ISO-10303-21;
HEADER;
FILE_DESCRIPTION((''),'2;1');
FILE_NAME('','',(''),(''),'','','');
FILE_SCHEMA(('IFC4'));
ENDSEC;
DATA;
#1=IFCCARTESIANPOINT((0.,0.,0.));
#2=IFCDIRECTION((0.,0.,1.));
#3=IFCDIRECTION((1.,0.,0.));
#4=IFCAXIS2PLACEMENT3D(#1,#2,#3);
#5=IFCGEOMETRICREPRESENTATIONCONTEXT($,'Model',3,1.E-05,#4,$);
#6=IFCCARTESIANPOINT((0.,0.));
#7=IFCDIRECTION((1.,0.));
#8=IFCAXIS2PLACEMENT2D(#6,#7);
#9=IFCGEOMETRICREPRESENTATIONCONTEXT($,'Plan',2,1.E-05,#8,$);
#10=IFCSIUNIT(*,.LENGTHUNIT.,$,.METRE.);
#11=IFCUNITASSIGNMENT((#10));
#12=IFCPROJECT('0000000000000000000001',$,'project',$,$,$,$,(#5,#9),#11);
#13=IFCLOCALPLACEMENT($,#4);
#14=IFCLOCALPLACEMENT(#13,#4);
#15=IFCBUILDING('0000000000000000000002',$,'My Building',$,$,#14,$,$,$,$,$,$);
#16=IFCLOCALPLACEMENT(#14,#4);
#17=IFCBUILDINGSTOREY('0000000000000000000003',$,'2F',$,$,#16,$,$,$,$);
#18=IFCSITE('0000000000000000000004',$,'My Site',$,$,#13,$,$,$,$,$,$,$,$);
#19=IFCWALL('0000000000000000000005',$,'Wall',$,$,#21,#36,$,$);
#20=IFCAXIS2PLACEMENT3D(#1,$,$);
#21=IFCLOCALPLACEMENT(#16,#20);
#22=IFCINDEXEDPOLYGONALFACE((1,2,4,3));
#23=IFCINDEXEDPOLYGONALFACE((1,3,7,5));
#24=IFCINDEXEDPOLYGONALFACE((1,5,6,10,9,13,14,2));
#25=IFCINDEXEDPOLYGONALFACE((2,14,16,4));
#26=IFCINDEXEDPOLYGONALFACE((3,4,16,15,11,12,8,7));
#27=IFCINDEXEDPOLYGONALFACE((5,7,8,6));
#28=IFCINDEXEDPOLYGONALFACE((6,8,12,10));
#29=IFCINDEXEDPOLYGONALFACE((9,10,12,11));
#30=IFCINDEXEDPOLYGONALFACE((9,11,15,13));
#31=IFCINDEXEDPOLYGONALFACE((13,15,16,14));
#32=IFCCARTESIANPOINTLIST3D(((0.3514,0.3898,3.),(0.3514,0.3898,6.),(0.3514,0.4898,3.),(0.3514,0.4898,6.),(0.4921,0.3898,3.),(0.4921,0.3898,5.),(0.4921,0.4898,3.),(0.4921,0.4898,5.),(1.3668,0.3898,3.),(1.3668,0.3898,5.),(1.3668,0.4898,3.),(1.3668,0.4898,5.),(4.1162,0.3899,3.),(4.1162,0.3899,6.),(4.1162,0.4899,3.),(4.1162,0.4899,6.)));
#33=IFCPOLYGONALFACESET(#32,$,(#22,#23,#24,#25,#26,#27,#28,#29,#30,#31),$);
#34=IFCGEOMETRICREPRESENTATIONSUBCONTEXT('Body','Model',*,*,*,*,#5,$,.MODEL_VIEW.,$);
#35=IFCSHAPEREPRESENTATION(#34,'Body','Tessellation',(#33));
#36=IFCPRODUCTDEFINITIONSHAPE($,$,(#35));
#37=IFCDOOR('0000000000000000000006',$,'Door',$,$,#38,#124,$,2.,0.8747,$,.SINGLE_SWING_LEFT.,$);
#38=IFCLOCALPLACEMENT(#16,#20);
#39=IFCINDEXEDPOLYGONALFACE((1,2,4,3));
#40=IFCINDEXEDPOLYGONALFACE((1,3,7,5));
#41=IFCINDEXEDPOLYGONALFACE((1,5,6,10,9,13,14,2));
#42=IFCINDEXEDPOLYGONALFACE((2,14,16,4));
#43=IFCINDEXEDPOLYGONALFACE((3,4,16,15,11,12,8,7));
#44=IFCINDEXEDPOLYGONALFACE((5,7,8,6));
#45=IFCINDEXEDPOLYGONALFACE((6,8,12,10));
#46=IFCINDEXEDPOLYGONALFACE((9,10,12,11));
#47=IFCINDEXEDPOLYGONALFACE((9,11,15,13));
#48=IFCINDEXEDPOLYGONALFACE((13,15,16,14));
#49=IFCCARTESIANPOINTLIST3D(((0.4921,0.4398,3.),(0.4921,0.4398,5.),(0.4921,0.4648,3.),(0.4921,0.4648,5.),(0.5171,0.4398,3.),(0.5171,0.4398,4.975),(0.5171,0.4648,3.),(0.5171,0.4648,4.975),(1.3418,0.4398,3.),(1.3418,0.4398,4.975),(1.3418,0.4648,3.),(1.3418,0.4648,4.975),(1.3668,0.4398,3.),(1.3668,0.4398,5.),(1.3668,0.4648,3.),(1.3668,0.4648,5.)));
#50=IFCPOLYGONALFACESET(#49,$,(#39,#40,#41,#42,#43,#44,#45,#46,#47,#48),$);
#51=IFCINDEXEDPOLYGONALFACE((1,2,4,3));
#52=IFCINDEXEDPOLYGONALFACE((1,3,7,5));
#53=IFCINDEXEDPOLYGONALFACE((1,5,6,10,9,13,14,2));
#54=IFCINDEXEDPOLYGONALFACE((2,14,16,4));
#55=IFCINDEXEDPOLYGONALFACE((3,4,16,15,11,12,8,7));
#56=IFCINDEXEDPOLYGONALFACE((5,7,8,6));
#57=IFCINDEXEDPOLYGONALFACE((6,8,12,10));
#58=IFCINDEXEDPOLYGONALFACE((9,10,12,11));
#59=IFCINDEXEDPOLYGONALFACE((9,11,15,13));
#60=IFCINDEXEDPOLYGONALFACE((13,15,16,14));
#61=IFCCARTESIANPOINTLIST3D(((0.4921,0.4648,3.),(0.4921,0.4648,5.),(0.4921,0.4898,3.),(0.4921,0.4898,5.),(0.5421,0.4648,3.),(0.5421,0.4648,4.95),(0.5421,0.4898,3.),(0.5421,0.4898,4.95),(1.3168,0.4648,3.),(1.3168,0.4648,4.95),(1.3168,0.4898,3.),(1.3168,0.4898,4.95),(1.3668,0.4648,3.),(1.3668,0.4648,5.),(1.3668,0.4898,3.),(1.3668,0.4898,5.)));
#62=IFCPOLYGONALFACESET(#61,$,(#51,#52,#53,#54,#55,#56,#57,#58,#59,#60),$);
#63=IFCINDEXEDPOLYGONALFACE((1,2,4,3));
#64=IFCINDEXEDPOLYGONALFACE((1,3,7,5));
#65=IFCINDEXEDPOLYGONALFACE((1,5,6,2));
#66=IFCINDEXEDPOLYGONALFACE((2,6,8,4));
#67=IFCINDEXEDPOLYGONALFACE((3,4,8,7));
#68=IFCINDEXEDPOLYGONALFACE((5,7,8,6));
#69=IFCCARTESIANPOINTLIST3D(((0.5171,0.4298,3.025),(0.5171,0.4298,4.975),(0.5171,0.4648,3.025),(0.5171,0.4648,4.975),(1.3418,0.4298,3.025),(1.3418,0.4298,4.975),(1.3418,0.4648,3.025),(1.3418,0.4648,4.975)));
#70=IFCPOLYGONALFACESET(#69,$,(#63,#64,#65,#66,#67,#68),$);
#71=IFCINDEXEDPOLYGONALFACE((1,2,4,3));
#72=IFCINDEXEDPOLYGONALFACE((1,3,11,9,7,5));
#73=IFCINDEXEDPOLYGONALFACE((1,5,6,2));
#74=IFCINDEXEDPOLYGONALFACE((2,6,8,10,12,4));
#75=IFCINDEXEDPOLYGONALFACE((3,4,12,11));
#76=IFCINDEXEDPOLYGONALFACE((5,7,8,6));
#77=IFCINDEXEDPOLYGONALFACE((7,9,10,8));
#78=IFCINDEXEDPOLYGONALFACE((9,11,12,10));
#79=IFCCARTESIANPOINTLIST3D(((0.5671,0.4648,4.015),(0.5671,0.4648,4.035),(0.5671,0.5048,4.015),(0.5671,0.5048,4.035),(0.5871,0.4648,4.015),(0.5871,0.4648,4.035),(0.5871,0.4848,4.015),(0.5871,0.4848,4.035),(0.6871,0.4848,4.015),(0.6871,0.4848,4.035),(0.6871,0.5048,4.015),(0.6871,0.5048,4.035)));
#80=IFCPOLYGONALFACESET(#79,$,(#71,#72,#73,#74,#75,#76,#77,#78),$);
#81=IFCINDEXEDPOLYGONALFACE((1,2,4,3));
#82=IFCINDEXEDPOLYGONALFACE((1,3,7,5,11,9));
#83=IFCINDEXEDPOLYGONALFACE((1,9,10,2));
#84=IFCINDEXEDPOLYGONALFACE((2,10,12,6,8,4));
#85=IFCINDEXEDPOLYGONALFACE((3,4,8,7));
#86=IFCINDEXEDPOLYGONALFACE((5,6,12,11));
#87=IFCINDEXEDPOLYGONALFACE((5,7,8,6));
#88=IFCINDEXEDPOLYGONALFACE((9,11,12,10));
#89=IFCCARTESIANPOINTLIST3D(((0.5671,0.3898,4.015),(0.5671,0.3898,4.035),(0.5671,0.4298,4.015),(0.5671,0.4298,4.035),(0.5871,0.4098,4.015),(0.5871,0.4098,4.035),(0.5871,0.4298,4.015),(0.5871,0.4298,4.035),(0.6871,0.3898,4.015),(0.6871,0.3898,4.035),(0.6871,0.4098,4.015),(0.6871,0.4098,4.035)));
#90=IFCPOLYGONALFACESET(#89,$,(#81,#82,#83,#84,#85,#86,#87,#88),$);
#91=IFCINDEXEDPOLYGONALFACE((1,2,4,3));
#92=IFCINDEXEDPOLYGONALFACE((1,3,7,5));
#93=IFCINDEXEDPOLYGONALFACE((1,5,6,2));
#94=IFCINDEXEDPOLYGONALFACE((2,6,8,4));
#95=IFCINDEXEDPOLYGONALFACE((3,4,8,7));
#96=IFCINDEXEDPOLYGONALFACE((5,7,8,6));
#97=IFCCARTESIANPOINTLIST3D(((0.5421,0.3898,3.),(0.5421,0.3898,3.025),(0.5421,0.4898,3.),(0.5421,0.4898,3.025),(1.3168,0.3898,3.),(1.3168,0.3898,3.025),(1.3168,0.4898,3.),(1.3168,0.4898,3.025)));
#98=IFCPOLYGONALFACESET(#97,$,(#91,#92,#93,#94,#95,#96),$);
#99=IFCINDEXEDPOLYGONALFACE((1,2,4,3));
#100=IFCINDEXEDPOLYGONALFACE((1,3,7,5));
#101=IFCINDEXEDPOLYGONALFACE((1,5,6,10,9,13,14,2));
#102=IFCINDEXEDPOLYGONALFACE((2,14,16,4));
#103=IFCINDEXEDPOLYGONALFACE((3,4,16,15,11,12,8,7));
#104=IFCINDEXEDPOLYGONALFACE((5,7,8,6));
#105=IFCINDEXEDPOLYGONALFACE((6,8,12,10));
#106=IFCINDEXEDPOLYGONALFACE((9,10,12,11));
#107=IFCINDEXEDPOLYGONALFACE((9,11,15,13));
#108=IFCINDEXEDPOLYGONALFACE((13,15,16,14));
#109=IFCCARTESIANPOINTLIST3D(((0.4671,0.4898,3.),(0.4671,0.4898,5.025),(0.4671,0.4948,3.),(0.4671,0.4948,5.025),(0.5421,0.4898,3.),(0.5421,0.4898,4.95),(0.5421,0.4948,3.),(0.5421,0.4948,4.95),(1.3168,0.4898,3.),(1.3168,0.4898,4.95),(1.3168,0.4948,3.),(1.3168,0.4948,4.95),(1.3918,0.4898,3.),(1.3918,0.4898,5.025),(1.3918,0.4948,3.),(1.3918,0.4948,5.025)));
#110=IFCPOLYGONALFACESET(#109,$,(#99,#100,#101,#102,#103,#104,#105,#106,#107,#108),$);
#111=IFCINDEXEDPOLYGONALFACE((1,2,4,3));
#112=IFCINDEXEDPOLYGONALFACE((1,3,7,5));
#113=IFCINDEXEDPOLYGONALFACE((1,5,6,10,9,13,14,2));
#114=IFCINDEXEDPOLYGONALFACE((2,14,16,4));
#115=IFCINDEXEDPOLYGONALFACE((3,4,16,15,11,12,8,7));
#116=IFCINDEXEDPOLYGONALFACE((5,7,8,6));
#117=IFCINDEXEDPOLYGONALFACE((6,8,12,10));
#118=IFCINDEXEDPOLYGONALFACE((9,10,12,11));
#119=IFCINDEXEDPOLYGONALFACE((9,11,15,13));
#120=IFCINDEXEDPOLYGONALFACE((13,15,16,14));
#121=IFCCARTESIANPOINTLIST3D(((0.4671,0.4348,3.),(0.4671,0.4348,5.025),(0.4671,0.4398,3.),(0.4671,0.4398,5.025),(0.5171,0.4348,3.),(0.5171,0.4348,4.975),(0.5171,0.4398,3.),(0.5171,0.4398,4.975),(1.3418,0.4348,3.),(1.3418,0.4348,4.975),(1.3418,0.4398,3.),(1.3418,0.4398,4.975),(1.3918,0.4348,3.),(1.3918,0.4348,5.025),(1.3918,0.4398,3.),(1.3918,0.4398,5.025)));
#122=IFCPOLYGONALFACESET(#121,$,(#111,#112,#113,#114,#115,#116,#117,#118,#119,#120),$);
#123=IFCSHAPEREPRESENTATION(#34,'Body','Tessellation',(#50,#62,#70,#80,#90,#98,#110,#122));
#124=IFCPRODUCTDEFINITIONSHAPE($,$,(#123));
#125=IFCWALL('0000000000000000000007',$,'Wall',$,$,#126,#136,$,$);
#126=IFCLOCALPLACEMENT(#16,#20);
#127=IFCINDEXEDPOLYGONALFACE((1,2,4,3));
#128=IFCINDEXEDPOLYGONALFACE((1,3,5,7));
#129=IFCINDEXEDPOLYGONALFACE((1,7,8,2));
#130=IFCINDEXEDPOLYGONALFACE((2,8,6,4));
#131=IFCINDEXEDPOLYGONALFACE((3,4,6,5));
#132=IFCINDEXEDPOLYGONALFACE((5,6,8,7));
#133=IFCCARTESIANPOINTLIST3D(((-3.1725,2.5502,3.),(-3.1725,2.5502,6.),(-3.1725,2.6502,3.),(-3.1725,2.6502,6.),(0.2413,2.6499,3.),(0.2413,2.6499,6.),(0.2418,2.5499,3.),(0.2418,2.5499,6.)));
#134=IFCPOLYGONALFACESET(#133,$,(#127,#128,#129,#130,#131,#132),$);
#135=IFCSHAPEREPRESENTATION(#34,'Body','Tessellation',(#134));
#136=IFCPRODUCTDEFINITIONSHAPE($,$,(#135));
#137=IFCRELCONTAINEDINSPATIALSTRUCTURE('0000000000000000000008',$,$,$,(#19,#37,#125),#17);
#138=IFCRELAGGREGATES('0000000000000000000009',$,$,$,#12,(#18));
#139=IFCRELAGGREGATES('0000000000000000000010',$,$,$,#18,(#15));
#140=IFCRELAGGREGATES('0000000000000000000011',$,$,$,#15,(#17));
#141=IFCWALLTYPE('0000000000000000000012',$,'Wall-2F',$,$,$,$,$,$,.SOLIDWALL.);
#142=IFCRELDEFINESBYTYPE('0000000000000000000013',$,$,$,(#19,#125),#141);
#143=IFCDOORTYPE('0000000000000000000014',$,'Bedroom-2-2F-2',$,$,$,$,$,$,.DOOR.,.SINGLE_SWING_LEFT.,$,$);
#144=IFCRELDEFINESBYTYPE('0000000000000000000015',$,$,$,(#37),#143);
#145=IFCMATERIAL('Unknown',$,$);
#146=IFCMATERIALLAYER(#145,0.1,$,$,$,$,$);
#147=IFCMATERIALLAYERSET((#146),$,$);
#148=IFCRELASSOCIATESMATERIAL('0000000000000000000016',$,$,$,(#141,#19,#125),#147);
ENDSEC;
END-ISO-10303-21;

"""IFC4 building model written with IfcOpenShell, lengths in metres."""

from ifc_helpers import new_model, entity, si_unit, frame, origin_with_axes, origin_2d_with_axis, place, context, subcontext, project, spatial, line, indexed_curve, outline, extrude, shape, source, transform, mapped, material, layer, layer_set, layer_usage, type_object, type_shapes, element, fill, save


model = new_model("IFC4")

# Units and contexts
model_context = context("Model", 3, precision=1e-05, world=origin_with_axes())
plan_context = context("Plan", 2, precision=1e-05, world=origin_2d_with_axis())
body_context_1 = subcontext(model_context, "Body", "Model", "MODEL_VIEW")
body_context_2 = subcontext(plan_context, "Body", "Plan", "PLAN_VIEW")
ifc_project = project(units=[si_unit("LENGTHUNIT", "METRE")], contexts=[model_context, plan_context])

# Site, building, storey
site_placement = place(None, origin_with_axes())
site = spatial("IfcSite", under=ifc_project, at=site_placement, Name="My Site")
building_placement = place(site_placement, origin_with_axes())
building = spatial("IfcBuilding", under=site, at=building_placement, Name="My Building")
storey_placement = place(building_placement, origin_with_axes())
storey = spatial("IfcBuildingStorey", under=building, at=storey_placement, Name="2F")

# Shared definitions
ifc_material = material(Name="Unknown")

# Shared definitions
ifc_layer_1 = layer(ifc_material, 0.1)
ifc_layer_set_1 = layer_set([ifc_layer_1])
wall_type = type_object("IfcWallType", Name="Wall-2F", PredefinedType="SOLIDWALL", material=ifc_layer_set_1)

# Wall, opening, door
ifc_layer_usage_1 = layer_usage(ifc_layer_set_1, "AXIS2", "POSITIVE", 0.0)
wall_1_placement = place(storey_placement, frame((0.3514, 0.3898, 3.0), z_axis=(0.0, 0.0, 1.0), x_axis=(1.0, 0.000024, 0.0)))
wall_1 = element("IfcWall", 1, at=wall_1_placement, inside=storey, type_object=wall_type, material=ifc_layer_usage_1, Name="Wall", context=body_context_1, shape_type="SweptSolid", body=[
    extrude(outline(indexed_curve([(0.0, 0.0), (0.0, 0.1), (3.7648, 0.1), (3.7648, 0.0)], segments=[line(1, 2, 3, 4, 1)])), origin_with_axes(), (0.0, 0.0, 1.0), 3.0),
])
shared_shape_1 = source(origin_with_axes(), body_context_1, "Body", "SweptSolid", [
    extrude(outline(indexed_curve([(0.0, 0.0), (0.8747, 0.0), (0.8747, 2.0), (0.0, 2.0)], segments=[line(1, 2, 3, 4, 1)])), frame((0.0, -0.6, 0.0), z_axis=(0.0, -1.0, 0.0), x_axis=(1.0, 0.0, 0.0)), (0.0, 0.0, -1.0), 1.2),
])
opening_1_placement = place(wall_1_placement, frame((0.1407, 0.015, 0.0), z_axis=(0.0, 0.0, 1.0), x_axis=(1.0, -0.000001, 0.0)))
opening_1 = element("IfcOpeningElement", 2, at=opening_1_placement, cuts=wall_1, PredefinedType="OPENING", context=body_context_1, shape_type="MappedRepresentation", body=[
    mapped(shared_shape_1, transform((0.0, 0.0, 0.0), x_axis=(1.0, 0.0, 0.0), y_axis=(0.0, 1.0, 0.0), z_axis=(0.0, 0.0, 1.0), scale=1.0)),
])
door_type_1 = type_object("IfcDoorType", Name="Bedroom-2-2F-2", OperationType="SINGLE_SWING_LEFT", PredefinedType="DOOR")
shared_shape_2 = source(origin_with_axes(), body_context_1, "Body", "SweptSolid", [
    extrude(outline(indexed_curve([(0.0, 0.0), (0.0, 2.0), (0.8747, 2.0), (0.8747, 0.0), (0.8497, 0.0), (0.8497, 1.975), (0.025, 1.975), (0.025, 0.0)], segments=[line(1, 2, 3, 4, 5, 6, 7, 8, 1)])), frame((0.0, 0.025, 0.0), z_axis=(0.0, -1.0, 0.0), x_axis=(1.0, 0.0, 0.0)), (0.0, 0.0, -1.0), 0.025),
    extrude(outline(indexed_curve([(0.0, 0.0), (0.0, 2.0), (0.8747, 2.0), (0.8747, 0.0), (0.8247, 0.0), (0.8247, 1.95), (0.05, 1.95), (0.05, 0.0)], segments=[line(1, 2, 3, 4, 5, 6, 7, 8, 1)])), frame((0.0, 0.0, 0.0), z_axis=(0.0, -1.0, 0.0), x_axis=(1.0, 0.0, 0.0)), (0.0, 0.0, -1.0), 0.025),
    extrude(outline(indexed_curve([(0.0, 0.0), (0.8247, 0.0), (0.8247, 0.035), (0.0, 0.035)], segments=[line(1, 2, 3, 4, 1)])), frame((0.025, 0.025, 0.025), z_axis=(0.0, 0.0, 1.0), x_axis=(1.0, 0.0, 0.0)), (0.0, 0.0, 1.0), 1.95),
    extrude(outline(indexed_curve([(0.0, 0.0), (0.0, -0.04), (-0.12, -0.04), (-0.12, -0.02), (-0.02, -0.02), (-0.02, 0.0)], segments=[line(1, 2, 3, 4, 5, 6, 1)])), frame((0.7997, 0.025, 1.015), z_axis=(0.0, 0.0, 1.0), x_axis=(1.0, 0.0, 0.0)), (0.0, 0.0, 1.0), 0.02),
    extrude(outline(indexed_curve([(0.0, 0.0), (0.0, 0.04), (-0.12, 0.04), (-0.12, 0.02), (-0.02, 0.02), (-0.02, 0.0)], segments=[line(1, 2, 3, 4, 5, 6, 1)])), frame((0.7997, 0.06, 1.015), z_axis=(0.0, 0.0, 1.0), x_axis=(1.0, 0.0, 0.0)), (0.0, 0.0, 1.0), 0.02),
    extrude(outline(indexed_curve([(0.0, 0.0), (0.7747, 0.0), (0.7747, 0.1), (0.0, 0.1)], segments=[line(1, 2, 3, 4, 1)])), frame((0.05, 0.0, 0.0), z_axis=(0.0, 0.0, 1.0), x_axis=(1.0, 0.0, 0.0)), (0.0, 0.0, 1.0), 0.025),
    extrude(outline(indexed_curve([(0.0, 0.0), (0.0, 2.025), (0.9247, 2.025), (0.9247, 0.0), (0.8497, 0.0), (0.8497, 1.95), (0.075, 1.95), (0.075, 0.0)], segments=[line(1, 2, 3, 4, 5, 6, 7, 8, 1)])), frame((-0.025, -0.005, 0.0), z_axis=(0.0, -1.0, 0.0), x_axis=(1.0, 0.0, 0.0)), (0.0, 0.0, -1.0), 0.005),
    extrude(outline(indexed_curve([(0.0, 0.0), (0.0, 2.025), (0.9247, 2.025), (0.9247, 0.0), (0.8747, 0.0), (0.8747, 1.975), (0.05, 1.975), (0.05, 0.0)], segments=[line(1, 2, 3, 4, 5, 6, 7, 8, 1)])), frame((-0.025, 0.05, 0.0), z_axis=(0.0, -1.0, 0.0), x_axis=(1.0, 0.0, 0.0)), (0.0, 0.0, -1.0), 0.005),
])
shared_shape_3 = source(origin_with_axes(), body_context_2, "Body", "Curve2D", [
    entity("IfcIndexedPolyCurve", entity("IfcCartesianPointList2D", [[0.0, 0.0], [0.0, 0.05], [0.025, 0.05], [0.025, 0.025], [0.05, 0.025], [0.05, 0.0]]), [entity("IfcLineIndex", [1, 2, 3, 4, 5, 6, 1])]),
    entity("IfcIndexedPolyCurve", entity("IfcCartesianPointList2D", [[0.8747, 0.0], [0.8747, 0.05], [0.8497, 0.05], [0.8497, 0.025], [0.8247, 0.025], [0.8247, 0.0]]), [entity("IfcLineIndex", [1, 2, 3, 4, 5, 6, 1])]),
    entity("IfcTrimmedCurve", entity("IfcEllipse", entity("IfcAxis2Placement2D", entity("IfcCartesianPoint", [0.06, 0.05]), entity("IfcDirection", [1.0, 0.0])), 0.7897, 0.8247), [entity("IfcCartesianPoint", [0.8497, 0.05])], [entity("IfcCartesianPoint", [0.06, 0.8747])], True, "CARTESIAN"),
    entity("IfcIndexedPolyCurve", entity("IfcCartesianPointList2D", [[0.025, 0.05], [0.06, 0.05], [0.06, 0.8747], [0.025, 0.8747]]), [entity("IfcLineIndex", [1, 2, 3, 4, 1])]),
])
type_shapes(door_type_1, [shared_shape_2, shared_shape_3])
door_1_placement = place(opening_1_placement, frame((0.8747, 0.085, 0.0), z_axis=(0.0, 0.0, 1.0), x_axis=(-1.0, 0.0, 0.0)))
door_1 = element("IfcDoor", 3, at=door_1_placement, inside=storey, type_object=door_type_1, Name="Door", OperationType="SINGLE_SWING_LEFT", OverallHeight=2.0, OverallWidth=0.8747, shapes=[
    shape(body_context_1, "Body", "MappedRepresentation", [mapped(shared_shape_2, transform((0.0, 0.0, 0.0), x_axis=(1.0, 0.0, 0.0), y_axis=(0.0, 1.0, 0.0), z_axis=(0.0, 0.0, 1.0), scale=1.0))]),
    shape(body_context_2, "Body", "MappedRepresentation", [mapped(shared_shape_3, transform((0.0, 0.0, 0.0), x_axis=(1.0, 0.0, 0.0), y_axis=(0.0, 1.0, 0.0), z_axis=(0.0, 0.0, 1.0), scale=1.0))]),
])
fill(opening_1, door_1)

# Wall
ifc_layer_usage_2 = layer_usage(ifc_layer_set_1, "AXIS2", "POSITIVE", 0.0)
wall_2_placement = place(storey_placement, frame((-3.1725, 2.5502, 3.0), z_axis=(0.0, 0.0, 1.0), x_axis=(1.0, -0.000076, 0.0)))
element("IfcWall", 4, at=wall_2_placement, inside=storey, type_object=wall_type, material=ifc_layer_usage_2, Name="Wall", context=body_context_1, shape_type="SweptSolid", body=[
    extrude(outline(indexed_curve([(0.0, 0.0), (0.0, 0.1), (3.4138, 0.1), (3.4144, 0.0)], segments=[line(1, 2, 3, 4, 1)])), origin_with_axes(), (0.0, 0.0, 1.0), 3.0),
])

save(model, "model.ifc")
